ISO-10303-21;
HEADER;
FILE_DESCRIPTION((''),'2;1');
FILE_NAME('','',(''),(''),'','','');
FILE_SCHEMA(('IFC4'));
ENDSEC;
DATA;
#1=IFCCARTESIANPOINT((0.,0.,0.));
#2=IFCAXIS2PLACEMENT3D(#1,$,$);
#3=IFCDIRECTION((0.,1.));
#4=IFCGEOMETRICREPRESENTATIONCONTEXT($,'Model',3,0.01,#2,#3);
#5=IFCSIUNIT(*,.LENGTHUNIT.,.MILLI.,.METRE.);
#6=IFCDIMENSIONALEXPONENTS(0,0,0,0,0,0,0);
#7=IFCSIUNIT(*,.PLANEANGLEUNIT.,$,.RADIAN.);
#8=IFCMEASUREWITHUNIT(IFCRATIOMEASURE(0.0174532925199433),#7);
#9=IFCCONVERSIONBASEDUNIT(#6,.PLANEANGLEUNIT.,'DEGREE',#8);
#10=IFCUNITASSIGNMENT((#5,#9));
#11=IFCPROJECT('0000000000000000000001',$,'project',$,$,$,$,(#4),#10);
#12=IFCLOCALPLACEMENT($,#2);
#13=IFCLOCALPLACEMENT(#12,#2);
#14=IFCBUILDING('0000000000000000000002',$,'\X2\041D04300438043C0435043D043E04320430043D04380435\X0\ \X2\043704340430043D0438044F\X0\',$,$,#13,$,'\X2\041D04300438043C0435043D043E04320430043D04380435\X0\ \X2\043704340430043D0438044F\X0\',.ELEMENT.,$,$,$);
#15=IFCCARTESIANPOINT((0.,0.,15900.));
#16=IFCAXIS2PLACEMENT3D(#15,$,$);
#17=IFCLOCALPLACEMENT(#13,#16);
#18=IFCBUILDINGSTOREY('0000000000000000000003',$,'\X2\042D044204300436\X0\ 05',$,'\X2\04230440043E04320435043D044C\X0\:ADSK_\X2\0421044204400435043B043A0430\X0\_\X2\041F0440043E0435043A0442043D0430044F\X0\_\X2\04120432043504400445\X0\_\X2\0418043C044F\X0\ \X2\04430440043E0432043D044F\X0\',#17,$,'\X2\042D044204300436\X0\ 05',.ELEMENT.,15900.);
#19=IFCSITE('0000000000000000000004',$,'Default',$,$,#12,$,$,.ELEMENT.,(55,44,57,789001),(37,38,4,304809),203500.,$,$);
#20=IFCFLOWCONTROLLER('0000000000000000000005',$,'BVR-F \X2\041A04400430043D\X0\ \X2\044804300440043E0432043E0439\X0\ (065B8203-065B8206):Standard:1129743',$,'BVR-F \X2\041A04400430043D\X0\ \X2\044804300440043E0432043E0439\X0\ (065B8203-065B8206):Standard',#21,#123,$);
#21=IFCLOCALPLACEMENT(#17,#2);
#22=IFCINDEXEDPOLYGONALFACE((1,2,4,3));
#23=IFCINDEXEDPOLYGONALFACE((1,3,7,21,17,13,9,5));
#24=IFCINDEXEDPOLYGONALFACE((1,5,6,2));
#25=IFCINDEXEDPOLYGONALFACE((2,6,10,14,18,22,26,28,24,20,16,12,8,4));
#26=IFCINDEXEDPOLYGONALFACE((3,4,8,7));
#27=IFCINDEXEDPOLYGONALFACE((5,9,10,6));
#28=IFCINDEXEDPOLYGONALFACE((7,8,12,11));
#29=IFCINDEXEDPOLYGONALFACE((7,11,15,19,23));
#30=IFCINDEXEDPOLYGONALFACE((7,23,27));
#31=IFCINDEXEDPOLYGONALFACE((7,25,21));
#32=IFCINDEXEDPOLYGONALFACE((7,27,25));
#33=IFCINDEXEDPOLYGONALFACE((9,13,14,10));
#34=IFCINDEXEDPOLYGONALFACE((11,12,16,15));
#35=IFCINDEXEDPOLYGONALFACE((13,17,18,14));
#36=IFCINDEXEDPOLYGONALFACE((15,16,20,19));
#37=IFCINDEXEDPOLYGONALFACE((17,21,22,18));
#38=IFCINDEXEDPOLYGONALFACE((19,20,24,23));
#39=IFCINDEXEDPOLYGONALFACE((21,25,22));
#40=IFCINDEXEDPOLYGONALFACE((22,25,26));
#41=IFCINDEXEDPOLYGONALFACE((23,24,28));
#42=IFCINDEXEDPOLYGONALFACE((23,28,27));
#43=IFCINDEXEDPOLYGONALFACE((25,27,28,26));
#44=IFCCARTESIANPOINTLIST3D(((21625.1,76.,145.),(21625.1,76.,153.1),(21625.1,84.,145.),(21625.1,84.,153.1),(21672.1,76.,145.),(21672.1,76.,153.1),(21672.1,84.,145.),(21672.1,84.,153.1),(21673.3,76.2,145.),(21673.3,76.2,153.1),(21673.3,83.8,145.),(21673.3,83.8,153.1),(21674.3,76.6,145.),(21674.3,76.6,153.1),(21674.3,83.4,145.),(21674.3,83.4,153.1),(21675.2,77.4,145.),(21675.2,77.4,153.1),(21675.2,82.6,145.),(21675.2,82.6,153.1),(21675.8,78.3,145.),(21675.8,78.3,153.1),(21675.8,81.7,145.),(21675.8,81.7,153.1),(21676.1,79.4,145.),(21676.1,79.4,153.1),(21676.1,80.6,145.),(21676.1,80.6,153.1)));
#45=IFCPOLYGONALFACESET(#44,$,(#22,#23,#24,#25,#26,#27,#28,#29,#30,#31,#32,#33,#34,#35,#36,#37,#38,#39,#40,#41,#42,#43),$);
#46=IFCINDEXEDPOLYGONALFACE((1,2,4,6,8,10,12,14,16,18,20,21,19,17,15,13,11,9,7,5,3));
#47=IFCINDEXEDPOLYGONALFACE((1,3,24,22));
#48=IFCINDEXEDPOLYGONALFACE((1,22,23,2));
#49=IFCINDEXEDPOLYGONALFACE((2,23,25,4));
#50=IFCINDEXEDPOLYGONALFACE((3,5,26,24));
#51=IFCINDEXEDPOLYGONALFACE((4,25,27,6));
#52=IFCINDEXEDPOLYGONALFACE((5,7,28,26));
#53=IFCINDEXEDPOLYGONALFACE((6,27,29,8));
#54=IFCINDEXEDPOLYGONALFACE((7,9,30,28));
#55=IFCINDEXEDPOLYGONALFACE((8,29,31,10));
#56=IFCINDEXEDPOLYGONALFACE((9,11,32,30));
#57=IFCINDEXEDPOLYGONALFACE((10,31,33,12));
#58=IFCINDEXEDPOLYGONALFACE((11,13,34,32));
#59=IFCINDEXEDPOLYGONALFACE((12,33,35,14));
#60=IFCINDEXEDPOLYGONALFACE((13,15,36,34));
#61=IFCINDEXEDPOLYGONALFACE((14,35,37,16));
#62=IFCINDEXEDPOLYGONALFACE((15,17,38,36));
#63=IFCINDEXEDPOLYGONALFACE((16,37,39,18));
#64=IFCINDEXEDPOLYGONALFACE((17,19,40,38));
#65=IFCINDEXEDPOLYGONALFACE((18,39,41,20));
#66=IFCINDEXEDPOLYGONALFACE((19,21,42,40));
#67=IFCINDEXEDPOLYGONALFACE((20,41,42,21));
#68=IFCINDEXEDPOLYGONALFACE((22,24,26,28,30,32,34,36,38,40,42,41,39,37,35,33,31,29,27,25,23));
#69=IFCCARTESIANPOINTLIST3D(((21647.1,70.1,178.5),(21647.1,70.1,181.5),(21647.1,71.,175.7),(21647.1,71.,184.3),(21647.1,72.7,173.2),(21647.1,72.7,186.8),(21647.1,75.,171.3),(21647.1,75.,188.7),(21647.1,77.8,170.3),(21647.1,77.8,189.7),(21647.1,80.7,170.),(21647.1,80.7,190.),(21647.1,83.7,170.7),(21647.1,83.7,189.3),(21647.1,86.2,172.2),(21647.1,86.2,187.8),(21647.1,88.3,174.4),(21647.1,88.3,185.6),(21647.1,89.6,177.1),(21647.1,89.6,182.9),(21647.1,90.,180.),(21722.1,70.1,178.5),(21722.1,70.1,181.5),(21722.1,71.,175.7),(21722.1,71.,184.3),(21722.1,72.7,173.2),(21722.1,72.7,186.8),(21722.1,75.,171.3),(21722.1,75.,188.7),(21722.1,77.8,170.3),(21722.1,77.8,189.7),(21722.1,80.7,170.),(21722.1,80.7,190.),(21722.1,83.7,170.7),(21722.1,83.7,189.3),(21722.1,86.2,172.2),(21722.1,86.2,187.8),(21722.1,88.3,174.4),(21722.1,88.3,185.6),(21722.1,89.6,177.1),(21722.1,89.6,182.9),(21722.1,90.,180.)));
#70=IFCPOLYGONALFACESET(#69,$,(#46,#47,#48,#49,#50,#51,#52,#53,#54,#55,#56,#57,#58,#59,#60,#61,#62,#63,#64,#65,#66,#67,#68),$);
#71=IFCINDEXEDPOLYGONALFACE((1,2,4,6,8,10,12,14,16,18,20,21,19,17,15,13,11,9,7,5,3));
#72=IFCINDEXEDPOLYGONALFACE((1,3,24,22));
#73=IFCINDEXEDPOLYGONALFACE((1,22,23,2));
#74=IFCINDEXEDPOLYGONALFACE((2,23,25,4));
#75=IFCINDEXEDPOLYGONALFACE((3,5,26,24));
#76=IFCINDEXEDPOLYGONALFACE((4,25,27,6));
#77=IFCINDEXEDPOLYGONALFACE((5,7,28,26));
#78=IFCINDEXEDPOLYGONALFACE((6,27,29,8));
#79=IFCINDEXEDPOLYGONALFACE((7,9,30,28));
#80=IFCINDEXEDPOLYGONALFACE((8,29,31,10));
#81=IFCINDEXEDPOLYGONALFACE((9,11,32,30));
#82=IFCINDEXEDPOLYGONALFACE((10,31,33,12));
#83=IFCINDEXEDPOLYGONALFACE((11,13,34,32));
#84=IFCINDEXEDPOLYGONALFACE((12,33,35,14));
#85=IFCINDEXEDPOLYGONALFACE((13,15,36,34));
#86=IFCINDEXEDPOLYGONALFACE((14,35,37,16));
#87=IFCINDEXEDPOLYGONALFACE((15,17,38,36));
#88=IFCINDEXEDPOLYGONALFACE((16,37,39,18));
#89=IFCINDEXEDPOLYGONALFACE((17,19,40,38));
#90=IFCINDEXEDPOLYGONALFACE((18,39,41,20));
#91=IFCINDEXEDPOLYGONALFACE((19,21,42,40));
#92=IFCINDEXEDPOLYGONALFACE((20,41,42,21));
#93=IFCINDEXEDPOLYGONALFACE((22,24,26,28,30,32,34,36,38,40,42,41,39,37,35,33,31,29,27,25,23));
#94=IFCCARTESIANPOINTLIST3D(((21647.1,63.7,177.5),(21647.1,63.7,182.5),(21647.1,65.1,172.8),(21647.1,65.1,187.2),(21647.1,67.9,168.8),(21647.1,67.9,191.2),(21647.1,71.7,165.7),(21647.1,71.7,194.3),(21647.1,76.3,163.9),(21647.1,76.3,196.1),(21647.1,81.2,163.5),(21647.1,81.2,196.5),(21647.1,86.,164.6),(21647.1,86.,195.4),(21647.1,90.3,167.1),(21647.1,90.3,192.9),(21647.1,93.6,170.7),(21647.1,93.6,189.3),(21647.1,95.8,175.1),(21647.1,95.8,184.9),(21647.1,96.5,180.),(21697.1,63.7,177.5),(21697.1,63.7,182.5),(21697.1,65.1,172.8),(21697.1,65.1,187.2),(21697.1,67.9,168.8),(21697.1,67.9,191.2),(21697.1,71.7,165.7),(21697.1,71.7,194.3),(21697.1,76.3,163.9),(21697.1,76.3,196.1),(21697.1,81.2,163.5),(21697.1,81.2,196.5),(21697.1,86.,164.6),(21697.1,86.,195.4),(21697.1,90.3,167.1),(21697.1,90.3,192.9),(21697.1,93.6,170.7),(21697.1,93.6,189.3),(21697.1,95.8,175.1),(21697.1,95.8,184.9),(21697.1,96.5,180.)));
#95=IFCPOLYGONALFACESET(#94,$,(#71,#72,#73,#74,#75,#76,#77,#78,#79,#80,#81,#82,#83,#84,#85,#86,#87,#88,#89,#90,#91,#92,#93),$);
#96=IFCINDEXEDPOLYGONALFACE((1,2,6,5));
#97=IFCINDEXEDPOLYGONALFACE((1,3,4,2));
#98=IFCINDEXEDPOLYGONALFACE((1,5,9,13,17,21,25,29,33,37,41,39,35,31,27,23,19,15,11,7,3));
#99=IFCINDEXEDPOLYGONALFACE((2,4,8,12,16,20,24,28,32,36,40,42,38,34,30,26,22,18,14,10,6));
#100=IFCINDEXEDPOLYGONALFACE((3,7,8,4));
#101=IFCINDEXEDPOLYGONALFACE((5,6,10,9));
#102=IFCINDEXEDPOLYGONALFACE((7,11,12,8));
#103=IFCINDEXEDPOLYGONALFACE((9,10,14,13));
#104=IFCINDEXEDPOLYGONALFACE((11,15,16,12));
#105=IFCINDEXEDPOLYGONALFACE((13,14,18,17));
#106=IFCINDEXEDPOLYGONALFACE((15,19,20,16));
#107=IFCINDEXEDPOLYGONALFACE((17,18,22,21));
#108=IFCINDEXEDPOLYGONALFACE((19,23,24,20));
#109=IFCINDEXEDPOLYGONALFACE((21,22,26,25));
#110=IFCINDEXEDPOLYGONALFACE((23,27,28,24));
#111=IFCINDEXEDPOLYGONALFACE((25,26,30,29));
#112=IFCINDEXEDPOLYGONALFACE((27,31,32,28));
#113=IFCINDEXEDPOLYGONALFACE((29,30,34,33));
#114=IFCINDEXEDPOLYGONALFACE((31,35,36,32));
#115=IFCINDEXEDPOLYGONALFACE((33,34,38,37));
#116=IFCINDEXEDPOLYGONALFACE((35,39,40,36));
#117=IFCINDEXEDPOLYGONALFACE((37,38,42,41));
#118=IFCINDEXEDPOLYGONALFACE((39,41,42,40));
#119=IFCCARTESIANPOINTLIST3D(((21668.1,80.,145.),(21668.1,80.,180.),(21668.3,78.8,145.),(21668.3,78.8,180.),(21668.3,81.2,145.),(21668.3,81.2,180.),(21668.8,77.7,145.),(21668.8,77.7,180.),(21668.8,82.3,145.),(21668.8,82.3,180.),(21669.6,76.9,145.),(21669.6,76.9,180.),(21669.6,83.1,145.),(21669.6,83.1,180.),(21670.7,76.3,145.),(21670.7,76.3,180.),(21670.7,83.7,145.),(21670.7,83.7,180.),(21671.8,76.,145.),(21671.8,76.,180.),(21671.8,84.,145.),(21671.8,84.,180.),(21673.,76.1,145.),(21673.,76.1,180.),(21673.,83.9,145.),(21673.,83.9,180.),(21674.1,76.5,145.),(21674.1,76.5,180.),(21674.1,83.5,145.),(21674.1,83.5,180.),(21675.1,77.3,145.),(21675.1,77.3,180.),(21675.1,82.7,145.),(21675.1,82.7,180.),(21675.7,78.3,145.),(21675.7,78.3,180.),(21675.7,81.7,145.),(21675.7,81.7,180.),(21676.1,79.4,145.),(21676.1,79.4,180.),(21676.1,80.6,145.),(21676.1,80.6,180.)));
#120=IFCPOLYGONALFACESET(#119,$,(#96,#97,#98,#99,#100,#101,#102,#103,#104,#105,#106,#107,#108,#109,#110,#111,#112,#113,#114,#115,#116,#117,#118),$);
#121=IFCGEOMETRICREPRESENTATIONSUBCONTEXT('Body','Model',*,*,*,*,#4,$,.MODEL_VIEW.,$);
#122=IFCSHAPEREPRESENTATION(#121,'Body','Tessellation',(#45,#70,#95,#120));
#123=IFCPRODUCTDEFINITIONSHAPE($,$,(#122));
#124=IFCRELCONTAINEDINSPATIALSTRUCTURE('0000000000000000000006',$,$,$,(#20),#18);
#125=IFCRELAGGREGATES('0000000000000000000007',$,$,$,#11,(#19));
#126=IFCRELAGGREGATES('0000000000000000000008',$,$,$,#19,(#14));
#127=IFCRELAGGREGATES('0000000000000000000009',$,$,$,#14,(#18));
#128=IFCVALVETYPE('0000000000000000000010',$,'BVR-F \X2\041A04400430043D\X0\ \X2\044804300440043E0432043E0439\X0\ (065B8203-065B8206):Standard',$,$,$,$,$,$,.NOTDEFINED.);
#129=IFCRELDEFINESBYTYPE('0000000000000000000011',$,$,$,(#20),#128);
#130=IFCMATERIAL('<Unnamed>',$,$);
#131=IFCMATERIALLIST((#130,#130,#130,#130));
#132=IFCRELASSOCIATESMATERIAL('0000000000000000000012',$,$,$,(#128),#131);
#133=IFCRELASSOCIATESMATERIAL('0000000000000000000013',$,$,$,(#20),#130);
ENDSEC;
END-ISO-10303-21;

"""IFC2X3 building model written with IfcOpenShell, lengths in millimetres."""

from ifc_helpers import new_model, entity, si_unit, converted_unit, direction, frame, frame_2d, origin, origin_2d_with_axis, place, context, subcontext, project, spatial, polyline, circle_curve, parameter, trimmed, segment, composite_curve, circle, outline, extrude, source, transform, mapped, material, material_list, type_object, type_shapes, element, save


model = new_model("IFC2X3")

# Units and contexts
model_context = context("Model", 3, precision=0.01, world=origin(), true_north=direction((0.0, 1.0)))
body_context = subcontext(model_context, "Body", "Model", "MODEL_VIEW")
ifc_project = project(units=[si_unit("LENGTHUNIT", "METRE", prefix="MILLI"), converted_unit("PLANEANGLEUNIT", "DEGREE", entity("IfcRatioMeasure", 0.0174532925199433), si_unit("PLANEANGLEUNIT", "RADIAN"), dimensions=[0, 0, 0, 0, 0, 0, 0])], contexts=[model_context])

# Site, building, storey
site_placement = place(None, origin())
site = spatial("IfcSite", under=ifc_project, at=site_placement, Name="Default", CompositionType="ELEMENT", RefLatitude=(55, 44, 57, 789001), RefLongitude=(37, 38, 4, 304809), RefElevation=203500.0)
building_placement = place(site_placement, origin())
building = spatial("IfcBuilding", under=site, at=building_placement, Name="Наименование здания", LongName="Наименование здания", CompositionType="ELEMENT")
storey_placement = place(building_placement, frame((0.0, 0.0, 15900.0)))
storey = spatial("IfcBuildingStorey", under=building, at=storey_placement, Name="Этаж 05", ObjectType="Уровень:ADSK_Стрелка_Проектная_Вверх_Имя уровня", LongName="Этаж 05", CompositionType="ELEMENT", Elevation=15900.0)

# Shared definitions
ifc_material = material(Name="<Unnamed>")

# Flow controller
ifc_material_list_1 = material_list([ifc_material, ifc_material, ifc_material, ifc_material])
valve_type_1 = type_object("IfcValveType", Name="BVR-F Кран шаровой (065B8203-065B8206):Standard", PredefinedType="NOTDEFINED", material=ifc_material_list_1)
shared_shape_1 = source(origin(), body_context, "Body", "SweptSolid", [
    extrude(outline(composite_curve([segment(polyline([(-23.5, -4.0), (23.5, -4.0)]), True, "CONTINUOUS"), segment(polyline([(23.5, -4.0), (23.5, 4.0)]), True, "CONTINUOUS"), segment(polyline([(23.5, 4.0), (-23.5, 4.0)]), True, "CONTINUOUS"), segment(trimmed(circle_curve(frame_2d((-23.5, 0.0), x_axis=(1.0, 0.0)), 4.0), [parameter(90.0)], [parameter(270.0)], True, "PARAMETER"), True, "CONTINUOUS")], self_intersect=False)), frame((23.5, 0.0, 26.9)), (0.0, 0.0, 1.0), 8.0),
    extrude(circle(Radius=10.0, at=origin_2d_with_axis()), frame((-50.0, 0.0, 0.0), z_axis=(1.0, 0.0, 0.0), x_axis=(0.0, 1.0, 0.0)), (0.0, 0.0, 1.0), 75.0),
    extrude(circle(Radius=16.5, at=origin_2d_with_axis()), frame((-25.0, 0.0, 0.0), z_axis=(1.0, 0.0, 0.0), x_axis=(0.0, 1.0, 0.0)), (0.0, 0.0, 1.0), 50.0),
    extrude(circle(Radius=4.0, at=origin_2d_with_axis()), origin(), (0.0, 0.0, 1.0), 35.0),
])
type_shapes(valve_type_1, [shared_shape_1])
flow_controller_1_placement = place(storey_placement, frame((21672.1, 80.0, 180.0), z_axis=(0.0, 0.0, -1.0), x_axis=(-1.0, 0.0, 0.0)))
element("IfcFlowController", 1, at=flow_controller_1_placement, inside=storey, type_object=valve_type_1, material=ifc_material, Name="BVR-F Кран шаровой (065B8203-065B8206):Standard:1129743", ObjectType="BVR-F Кран шаровой (065B8203-065B8206):Standard", context=body_context, shape_type="MappedRepresentation", body=[
    mapped(shared_shape_1, transform((0.0, 0.0, 0.0), scale=1.0)),
])

save(model, "model.ifc")
